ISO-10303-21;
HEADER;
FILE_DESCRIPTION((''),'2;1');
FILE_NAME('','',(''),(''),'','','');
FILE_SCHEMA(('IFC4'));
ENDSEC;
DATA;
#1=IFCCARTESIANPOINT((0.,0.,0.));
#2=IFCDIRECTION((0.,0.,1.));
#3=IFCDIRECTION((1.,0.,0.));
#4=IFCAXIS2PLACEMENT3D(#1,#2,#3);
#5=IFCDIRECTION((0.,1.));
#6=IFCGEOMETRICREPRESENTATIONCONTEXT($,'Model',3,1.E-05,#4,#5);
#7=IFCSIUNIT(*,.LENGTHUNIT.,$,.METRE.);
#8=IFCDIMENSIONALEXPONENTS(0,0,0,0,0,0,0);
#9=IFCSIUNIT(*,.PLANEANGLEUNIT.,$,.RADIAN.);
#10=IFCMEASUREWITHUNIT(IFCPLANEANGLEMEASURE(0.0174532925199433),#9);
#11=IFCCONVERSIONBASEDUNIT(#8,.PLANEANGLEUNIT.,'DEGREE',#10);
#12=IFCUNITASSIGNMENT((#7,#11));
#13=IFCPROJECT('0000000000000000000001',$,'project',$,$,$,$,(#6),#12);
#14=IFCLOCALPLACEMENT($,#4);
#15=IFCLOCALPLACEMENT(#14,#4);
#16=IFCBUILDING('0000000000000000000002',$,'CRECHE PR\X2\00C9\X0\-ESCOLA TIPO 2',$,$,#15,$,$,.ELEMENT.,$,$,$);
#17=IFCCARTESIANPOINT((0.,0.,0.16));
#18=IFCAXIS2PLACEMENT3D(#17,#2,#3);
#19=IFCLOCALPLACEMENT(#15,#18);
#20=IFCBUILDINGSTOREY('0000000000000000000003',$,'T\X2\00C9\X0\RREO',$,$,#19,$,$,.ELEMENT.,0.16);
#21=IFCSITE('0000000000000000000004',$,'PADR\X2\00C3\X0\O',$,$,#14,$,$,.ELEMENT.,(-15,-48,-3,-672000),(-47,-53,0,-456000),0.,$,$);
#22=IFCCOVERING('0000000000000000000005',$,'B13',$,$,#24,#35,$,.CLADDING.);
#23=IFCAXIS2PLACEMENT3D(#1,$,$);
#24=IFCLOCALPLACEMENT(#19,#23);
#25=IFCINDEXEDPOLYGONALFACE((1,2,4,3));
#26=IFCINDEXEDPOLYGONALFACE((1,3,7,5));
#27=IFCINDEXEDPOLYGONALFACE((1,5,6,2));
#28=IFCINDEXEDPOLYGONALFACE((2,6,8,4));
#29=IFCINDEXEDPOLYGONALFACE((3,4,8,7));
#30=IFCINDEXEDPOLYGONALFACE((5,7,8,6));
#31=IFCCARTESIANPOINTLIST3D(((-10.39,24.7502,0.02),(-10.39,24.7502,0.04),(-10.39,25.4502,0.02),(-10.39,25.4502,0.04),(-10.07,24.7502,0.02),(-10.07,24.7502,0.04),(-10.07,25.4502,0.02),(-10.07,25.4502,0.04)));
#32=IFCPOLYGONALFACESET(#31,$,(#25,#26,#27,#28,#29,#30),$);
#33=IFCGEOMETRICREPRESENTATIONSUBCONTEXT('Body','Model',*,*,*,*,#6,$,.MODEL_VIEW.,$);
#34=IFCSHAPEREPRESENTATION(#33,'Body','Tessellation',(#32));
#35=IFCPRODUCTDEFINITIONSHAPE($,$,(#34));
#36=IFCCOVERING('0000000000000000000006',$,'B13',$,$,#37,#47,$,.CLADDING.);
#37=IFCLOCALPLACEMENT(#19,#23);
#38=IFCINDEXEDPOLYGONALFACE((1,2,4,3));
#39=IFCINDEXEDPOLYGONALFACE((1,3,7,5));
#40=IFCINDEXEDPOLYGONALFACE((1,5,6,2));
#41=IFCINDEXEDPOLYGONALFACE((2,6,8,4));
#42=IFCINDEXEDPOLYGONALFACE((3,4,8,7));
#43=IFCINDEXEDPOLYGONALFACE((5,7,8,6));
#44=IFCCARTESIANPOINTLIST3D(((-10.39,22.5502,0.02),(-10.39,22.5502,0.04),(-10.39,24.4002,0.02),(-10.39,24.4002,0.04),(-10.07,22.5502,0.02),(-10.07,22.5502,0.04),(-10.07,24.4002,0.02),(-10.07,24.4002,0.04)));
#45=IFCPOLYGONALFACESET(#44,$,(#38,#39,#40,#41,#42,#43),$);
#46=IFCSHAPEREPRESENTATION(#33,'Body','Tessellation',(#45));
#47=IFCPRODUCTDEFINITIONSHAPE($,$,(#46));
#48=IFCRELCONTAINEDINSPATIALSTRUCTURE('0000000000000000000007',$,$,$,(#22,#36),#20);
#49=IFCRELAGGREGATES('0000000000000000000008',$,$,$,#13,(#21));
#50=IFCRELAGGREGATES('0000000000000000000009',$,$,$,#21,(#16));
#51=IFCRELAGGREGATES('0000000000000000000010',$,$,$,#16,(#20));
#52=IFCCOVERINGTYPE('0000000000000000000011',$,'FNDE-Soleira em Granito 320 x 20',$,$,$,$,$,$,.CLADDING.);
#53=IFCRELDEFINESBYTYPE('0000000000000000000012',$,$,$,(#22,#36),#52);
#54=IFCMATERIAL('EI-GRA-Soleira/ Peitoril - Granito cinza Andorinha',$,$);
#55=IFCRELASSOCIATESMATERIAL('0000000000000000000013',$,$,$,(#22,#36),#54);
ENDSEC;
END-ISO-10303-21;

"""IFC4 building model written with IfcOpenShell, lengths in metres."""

from ifc_helpers import new_model, entity, si_unit, converted_unit, direction, frame, origin_with_axes, place, context, subcontext, project, spatial, line, indexed_curve, outline, extrude, material, material_profile, profile_set, type_object, element, save


model = new_model("IFC4")

# Units and contexts
model_context = context("Model", 3, precision=1e-05, world=origin_with_axes(), true_north=direction((0.0, 1.0)))
body_context = subcontext(model_context, "Body", "Model", "MODEL_VIEW")
ifc_project = project(units=[si_unit("LENGTHUNIT", "METRE"), converted_unit("PLANEANGLEUNIT", "DEGREE", entity("IfcPlaneAngleMeasure", 0.0174532925199433), si_unit("PLANEANGLEUNIT", "RADIAN"), dimensions=[0, 0, 0, 0, 0, 0, 0])], contexts=[model_context])

# Site, building, storey
site_placement = place(None, origin_with_axes())
site = spatial("IfcSite", under=ifc_project, at=site_placement, Name="PADRÃO", CompositionType="ELEMENT", RefLatitude=(-15, -48, -3, -672000), RefLongitude=(-47, -53, 0, -456000), RefElevation=0.0)
building_placement = place(site_placement, origin_with_axes())
building = spatial("IfcBuilding", under=site, at=building_placement, Name="CRECHE PRÉ-ESCOLA TIPO 2", CompositionType="ELEMENT")
storey_placement = place(building_placement, frame((0.0, 0.0, 0.16), z_axis=(0.0, 0.0, 1.0), x_axis=(1.0, 0.0, 0.0)))
storey = spatial("IfcBuildingStorey", under=building, at=storey_placement, Name="TÉRREO", CompositionType="ELEMENT", Elevation=0.16)

# Coverings
ifc_material_1 = material(Name="EI-GRA-Soleira/ Peitoril - Granito cinza Andorinha")
ifc_material_profile_1 = material_profile(ifc_material_1, outline(indexed_curve([(0.0, 0.01), (0.32, 0.01), (0.32, 0.03), (0.0, 0.03)], segments=[line(1, 2, 3, 4, 1)])), Name="EI-GRA-Soleira/ Peitoril - Granito cinza Andorinha")
ifc_profile_set_1 = profile_set([ifc_material_profile_1], Name="FNDE-Soleira em Granito")
covering_type_1 = type_object("IfcCoveringType", Name="FNDE-Soleira em Granito 320 x 20", PredefinedType="CLADDING")
covering_1_placement = place(storey_placement, frame((-10.39, 24.7502, 0.01), z_axis=(0.0, 0.0, 1.0), x_axis=(1.0, 0.0, 0.0)))
element("IfcCovering", 1, at=covering_1_placement, inside=storey, type_object=covering_type_1, material=ifc_profile_set_1, Name="B13", PredefinedType="CLADDING", context=body_context, shape_type="SweptSolid", body=[
    extrude(outline(indexed_curve([(0.0, 0.01), (0.32, 0.01), (0.32, 0.03), (0.0, 0.03)], segments=[line(1, 2, 3, 4, 1)])), frame((0.0, 0.7, 0.0), z_axis=(0.0, -1.0, 0.0), x_axis=(1.0, 0.0, 0.0)), (0.0, 0.0, 1.0), 0.7),
])
covering_2_placement = place(storey_placement, frame((-10.39, 22.5502, 0.01), z_axis=(0.0, 0.0, 1.0), x_axis=(1.0, 0.0, 0.0)))
element("IfcCovering", 2, at=covering_2_placement, inside=storey, type_object=covering_type_1, material=ifc_profile_set_1, Name="B13", PredefinedType="CLADDING", context=body_context, shape_type="SweptSolid", body=[
    extrude(outline(indexed_curve([(0.0, 0.01), (0.32, 0.01), (0.32, 0.03), (0.0, 0.03)], segments=[line(1, 2, 3, 4, 1)])), frame((0.0, 1.85, 0.0), z_axis=(0.0, -1.0, 0.0), x_axis=(1.0, 0.0, 0.0)), (0.0, 0.0, 1.0), 1.85),
])

save(model, "model.ifc")
